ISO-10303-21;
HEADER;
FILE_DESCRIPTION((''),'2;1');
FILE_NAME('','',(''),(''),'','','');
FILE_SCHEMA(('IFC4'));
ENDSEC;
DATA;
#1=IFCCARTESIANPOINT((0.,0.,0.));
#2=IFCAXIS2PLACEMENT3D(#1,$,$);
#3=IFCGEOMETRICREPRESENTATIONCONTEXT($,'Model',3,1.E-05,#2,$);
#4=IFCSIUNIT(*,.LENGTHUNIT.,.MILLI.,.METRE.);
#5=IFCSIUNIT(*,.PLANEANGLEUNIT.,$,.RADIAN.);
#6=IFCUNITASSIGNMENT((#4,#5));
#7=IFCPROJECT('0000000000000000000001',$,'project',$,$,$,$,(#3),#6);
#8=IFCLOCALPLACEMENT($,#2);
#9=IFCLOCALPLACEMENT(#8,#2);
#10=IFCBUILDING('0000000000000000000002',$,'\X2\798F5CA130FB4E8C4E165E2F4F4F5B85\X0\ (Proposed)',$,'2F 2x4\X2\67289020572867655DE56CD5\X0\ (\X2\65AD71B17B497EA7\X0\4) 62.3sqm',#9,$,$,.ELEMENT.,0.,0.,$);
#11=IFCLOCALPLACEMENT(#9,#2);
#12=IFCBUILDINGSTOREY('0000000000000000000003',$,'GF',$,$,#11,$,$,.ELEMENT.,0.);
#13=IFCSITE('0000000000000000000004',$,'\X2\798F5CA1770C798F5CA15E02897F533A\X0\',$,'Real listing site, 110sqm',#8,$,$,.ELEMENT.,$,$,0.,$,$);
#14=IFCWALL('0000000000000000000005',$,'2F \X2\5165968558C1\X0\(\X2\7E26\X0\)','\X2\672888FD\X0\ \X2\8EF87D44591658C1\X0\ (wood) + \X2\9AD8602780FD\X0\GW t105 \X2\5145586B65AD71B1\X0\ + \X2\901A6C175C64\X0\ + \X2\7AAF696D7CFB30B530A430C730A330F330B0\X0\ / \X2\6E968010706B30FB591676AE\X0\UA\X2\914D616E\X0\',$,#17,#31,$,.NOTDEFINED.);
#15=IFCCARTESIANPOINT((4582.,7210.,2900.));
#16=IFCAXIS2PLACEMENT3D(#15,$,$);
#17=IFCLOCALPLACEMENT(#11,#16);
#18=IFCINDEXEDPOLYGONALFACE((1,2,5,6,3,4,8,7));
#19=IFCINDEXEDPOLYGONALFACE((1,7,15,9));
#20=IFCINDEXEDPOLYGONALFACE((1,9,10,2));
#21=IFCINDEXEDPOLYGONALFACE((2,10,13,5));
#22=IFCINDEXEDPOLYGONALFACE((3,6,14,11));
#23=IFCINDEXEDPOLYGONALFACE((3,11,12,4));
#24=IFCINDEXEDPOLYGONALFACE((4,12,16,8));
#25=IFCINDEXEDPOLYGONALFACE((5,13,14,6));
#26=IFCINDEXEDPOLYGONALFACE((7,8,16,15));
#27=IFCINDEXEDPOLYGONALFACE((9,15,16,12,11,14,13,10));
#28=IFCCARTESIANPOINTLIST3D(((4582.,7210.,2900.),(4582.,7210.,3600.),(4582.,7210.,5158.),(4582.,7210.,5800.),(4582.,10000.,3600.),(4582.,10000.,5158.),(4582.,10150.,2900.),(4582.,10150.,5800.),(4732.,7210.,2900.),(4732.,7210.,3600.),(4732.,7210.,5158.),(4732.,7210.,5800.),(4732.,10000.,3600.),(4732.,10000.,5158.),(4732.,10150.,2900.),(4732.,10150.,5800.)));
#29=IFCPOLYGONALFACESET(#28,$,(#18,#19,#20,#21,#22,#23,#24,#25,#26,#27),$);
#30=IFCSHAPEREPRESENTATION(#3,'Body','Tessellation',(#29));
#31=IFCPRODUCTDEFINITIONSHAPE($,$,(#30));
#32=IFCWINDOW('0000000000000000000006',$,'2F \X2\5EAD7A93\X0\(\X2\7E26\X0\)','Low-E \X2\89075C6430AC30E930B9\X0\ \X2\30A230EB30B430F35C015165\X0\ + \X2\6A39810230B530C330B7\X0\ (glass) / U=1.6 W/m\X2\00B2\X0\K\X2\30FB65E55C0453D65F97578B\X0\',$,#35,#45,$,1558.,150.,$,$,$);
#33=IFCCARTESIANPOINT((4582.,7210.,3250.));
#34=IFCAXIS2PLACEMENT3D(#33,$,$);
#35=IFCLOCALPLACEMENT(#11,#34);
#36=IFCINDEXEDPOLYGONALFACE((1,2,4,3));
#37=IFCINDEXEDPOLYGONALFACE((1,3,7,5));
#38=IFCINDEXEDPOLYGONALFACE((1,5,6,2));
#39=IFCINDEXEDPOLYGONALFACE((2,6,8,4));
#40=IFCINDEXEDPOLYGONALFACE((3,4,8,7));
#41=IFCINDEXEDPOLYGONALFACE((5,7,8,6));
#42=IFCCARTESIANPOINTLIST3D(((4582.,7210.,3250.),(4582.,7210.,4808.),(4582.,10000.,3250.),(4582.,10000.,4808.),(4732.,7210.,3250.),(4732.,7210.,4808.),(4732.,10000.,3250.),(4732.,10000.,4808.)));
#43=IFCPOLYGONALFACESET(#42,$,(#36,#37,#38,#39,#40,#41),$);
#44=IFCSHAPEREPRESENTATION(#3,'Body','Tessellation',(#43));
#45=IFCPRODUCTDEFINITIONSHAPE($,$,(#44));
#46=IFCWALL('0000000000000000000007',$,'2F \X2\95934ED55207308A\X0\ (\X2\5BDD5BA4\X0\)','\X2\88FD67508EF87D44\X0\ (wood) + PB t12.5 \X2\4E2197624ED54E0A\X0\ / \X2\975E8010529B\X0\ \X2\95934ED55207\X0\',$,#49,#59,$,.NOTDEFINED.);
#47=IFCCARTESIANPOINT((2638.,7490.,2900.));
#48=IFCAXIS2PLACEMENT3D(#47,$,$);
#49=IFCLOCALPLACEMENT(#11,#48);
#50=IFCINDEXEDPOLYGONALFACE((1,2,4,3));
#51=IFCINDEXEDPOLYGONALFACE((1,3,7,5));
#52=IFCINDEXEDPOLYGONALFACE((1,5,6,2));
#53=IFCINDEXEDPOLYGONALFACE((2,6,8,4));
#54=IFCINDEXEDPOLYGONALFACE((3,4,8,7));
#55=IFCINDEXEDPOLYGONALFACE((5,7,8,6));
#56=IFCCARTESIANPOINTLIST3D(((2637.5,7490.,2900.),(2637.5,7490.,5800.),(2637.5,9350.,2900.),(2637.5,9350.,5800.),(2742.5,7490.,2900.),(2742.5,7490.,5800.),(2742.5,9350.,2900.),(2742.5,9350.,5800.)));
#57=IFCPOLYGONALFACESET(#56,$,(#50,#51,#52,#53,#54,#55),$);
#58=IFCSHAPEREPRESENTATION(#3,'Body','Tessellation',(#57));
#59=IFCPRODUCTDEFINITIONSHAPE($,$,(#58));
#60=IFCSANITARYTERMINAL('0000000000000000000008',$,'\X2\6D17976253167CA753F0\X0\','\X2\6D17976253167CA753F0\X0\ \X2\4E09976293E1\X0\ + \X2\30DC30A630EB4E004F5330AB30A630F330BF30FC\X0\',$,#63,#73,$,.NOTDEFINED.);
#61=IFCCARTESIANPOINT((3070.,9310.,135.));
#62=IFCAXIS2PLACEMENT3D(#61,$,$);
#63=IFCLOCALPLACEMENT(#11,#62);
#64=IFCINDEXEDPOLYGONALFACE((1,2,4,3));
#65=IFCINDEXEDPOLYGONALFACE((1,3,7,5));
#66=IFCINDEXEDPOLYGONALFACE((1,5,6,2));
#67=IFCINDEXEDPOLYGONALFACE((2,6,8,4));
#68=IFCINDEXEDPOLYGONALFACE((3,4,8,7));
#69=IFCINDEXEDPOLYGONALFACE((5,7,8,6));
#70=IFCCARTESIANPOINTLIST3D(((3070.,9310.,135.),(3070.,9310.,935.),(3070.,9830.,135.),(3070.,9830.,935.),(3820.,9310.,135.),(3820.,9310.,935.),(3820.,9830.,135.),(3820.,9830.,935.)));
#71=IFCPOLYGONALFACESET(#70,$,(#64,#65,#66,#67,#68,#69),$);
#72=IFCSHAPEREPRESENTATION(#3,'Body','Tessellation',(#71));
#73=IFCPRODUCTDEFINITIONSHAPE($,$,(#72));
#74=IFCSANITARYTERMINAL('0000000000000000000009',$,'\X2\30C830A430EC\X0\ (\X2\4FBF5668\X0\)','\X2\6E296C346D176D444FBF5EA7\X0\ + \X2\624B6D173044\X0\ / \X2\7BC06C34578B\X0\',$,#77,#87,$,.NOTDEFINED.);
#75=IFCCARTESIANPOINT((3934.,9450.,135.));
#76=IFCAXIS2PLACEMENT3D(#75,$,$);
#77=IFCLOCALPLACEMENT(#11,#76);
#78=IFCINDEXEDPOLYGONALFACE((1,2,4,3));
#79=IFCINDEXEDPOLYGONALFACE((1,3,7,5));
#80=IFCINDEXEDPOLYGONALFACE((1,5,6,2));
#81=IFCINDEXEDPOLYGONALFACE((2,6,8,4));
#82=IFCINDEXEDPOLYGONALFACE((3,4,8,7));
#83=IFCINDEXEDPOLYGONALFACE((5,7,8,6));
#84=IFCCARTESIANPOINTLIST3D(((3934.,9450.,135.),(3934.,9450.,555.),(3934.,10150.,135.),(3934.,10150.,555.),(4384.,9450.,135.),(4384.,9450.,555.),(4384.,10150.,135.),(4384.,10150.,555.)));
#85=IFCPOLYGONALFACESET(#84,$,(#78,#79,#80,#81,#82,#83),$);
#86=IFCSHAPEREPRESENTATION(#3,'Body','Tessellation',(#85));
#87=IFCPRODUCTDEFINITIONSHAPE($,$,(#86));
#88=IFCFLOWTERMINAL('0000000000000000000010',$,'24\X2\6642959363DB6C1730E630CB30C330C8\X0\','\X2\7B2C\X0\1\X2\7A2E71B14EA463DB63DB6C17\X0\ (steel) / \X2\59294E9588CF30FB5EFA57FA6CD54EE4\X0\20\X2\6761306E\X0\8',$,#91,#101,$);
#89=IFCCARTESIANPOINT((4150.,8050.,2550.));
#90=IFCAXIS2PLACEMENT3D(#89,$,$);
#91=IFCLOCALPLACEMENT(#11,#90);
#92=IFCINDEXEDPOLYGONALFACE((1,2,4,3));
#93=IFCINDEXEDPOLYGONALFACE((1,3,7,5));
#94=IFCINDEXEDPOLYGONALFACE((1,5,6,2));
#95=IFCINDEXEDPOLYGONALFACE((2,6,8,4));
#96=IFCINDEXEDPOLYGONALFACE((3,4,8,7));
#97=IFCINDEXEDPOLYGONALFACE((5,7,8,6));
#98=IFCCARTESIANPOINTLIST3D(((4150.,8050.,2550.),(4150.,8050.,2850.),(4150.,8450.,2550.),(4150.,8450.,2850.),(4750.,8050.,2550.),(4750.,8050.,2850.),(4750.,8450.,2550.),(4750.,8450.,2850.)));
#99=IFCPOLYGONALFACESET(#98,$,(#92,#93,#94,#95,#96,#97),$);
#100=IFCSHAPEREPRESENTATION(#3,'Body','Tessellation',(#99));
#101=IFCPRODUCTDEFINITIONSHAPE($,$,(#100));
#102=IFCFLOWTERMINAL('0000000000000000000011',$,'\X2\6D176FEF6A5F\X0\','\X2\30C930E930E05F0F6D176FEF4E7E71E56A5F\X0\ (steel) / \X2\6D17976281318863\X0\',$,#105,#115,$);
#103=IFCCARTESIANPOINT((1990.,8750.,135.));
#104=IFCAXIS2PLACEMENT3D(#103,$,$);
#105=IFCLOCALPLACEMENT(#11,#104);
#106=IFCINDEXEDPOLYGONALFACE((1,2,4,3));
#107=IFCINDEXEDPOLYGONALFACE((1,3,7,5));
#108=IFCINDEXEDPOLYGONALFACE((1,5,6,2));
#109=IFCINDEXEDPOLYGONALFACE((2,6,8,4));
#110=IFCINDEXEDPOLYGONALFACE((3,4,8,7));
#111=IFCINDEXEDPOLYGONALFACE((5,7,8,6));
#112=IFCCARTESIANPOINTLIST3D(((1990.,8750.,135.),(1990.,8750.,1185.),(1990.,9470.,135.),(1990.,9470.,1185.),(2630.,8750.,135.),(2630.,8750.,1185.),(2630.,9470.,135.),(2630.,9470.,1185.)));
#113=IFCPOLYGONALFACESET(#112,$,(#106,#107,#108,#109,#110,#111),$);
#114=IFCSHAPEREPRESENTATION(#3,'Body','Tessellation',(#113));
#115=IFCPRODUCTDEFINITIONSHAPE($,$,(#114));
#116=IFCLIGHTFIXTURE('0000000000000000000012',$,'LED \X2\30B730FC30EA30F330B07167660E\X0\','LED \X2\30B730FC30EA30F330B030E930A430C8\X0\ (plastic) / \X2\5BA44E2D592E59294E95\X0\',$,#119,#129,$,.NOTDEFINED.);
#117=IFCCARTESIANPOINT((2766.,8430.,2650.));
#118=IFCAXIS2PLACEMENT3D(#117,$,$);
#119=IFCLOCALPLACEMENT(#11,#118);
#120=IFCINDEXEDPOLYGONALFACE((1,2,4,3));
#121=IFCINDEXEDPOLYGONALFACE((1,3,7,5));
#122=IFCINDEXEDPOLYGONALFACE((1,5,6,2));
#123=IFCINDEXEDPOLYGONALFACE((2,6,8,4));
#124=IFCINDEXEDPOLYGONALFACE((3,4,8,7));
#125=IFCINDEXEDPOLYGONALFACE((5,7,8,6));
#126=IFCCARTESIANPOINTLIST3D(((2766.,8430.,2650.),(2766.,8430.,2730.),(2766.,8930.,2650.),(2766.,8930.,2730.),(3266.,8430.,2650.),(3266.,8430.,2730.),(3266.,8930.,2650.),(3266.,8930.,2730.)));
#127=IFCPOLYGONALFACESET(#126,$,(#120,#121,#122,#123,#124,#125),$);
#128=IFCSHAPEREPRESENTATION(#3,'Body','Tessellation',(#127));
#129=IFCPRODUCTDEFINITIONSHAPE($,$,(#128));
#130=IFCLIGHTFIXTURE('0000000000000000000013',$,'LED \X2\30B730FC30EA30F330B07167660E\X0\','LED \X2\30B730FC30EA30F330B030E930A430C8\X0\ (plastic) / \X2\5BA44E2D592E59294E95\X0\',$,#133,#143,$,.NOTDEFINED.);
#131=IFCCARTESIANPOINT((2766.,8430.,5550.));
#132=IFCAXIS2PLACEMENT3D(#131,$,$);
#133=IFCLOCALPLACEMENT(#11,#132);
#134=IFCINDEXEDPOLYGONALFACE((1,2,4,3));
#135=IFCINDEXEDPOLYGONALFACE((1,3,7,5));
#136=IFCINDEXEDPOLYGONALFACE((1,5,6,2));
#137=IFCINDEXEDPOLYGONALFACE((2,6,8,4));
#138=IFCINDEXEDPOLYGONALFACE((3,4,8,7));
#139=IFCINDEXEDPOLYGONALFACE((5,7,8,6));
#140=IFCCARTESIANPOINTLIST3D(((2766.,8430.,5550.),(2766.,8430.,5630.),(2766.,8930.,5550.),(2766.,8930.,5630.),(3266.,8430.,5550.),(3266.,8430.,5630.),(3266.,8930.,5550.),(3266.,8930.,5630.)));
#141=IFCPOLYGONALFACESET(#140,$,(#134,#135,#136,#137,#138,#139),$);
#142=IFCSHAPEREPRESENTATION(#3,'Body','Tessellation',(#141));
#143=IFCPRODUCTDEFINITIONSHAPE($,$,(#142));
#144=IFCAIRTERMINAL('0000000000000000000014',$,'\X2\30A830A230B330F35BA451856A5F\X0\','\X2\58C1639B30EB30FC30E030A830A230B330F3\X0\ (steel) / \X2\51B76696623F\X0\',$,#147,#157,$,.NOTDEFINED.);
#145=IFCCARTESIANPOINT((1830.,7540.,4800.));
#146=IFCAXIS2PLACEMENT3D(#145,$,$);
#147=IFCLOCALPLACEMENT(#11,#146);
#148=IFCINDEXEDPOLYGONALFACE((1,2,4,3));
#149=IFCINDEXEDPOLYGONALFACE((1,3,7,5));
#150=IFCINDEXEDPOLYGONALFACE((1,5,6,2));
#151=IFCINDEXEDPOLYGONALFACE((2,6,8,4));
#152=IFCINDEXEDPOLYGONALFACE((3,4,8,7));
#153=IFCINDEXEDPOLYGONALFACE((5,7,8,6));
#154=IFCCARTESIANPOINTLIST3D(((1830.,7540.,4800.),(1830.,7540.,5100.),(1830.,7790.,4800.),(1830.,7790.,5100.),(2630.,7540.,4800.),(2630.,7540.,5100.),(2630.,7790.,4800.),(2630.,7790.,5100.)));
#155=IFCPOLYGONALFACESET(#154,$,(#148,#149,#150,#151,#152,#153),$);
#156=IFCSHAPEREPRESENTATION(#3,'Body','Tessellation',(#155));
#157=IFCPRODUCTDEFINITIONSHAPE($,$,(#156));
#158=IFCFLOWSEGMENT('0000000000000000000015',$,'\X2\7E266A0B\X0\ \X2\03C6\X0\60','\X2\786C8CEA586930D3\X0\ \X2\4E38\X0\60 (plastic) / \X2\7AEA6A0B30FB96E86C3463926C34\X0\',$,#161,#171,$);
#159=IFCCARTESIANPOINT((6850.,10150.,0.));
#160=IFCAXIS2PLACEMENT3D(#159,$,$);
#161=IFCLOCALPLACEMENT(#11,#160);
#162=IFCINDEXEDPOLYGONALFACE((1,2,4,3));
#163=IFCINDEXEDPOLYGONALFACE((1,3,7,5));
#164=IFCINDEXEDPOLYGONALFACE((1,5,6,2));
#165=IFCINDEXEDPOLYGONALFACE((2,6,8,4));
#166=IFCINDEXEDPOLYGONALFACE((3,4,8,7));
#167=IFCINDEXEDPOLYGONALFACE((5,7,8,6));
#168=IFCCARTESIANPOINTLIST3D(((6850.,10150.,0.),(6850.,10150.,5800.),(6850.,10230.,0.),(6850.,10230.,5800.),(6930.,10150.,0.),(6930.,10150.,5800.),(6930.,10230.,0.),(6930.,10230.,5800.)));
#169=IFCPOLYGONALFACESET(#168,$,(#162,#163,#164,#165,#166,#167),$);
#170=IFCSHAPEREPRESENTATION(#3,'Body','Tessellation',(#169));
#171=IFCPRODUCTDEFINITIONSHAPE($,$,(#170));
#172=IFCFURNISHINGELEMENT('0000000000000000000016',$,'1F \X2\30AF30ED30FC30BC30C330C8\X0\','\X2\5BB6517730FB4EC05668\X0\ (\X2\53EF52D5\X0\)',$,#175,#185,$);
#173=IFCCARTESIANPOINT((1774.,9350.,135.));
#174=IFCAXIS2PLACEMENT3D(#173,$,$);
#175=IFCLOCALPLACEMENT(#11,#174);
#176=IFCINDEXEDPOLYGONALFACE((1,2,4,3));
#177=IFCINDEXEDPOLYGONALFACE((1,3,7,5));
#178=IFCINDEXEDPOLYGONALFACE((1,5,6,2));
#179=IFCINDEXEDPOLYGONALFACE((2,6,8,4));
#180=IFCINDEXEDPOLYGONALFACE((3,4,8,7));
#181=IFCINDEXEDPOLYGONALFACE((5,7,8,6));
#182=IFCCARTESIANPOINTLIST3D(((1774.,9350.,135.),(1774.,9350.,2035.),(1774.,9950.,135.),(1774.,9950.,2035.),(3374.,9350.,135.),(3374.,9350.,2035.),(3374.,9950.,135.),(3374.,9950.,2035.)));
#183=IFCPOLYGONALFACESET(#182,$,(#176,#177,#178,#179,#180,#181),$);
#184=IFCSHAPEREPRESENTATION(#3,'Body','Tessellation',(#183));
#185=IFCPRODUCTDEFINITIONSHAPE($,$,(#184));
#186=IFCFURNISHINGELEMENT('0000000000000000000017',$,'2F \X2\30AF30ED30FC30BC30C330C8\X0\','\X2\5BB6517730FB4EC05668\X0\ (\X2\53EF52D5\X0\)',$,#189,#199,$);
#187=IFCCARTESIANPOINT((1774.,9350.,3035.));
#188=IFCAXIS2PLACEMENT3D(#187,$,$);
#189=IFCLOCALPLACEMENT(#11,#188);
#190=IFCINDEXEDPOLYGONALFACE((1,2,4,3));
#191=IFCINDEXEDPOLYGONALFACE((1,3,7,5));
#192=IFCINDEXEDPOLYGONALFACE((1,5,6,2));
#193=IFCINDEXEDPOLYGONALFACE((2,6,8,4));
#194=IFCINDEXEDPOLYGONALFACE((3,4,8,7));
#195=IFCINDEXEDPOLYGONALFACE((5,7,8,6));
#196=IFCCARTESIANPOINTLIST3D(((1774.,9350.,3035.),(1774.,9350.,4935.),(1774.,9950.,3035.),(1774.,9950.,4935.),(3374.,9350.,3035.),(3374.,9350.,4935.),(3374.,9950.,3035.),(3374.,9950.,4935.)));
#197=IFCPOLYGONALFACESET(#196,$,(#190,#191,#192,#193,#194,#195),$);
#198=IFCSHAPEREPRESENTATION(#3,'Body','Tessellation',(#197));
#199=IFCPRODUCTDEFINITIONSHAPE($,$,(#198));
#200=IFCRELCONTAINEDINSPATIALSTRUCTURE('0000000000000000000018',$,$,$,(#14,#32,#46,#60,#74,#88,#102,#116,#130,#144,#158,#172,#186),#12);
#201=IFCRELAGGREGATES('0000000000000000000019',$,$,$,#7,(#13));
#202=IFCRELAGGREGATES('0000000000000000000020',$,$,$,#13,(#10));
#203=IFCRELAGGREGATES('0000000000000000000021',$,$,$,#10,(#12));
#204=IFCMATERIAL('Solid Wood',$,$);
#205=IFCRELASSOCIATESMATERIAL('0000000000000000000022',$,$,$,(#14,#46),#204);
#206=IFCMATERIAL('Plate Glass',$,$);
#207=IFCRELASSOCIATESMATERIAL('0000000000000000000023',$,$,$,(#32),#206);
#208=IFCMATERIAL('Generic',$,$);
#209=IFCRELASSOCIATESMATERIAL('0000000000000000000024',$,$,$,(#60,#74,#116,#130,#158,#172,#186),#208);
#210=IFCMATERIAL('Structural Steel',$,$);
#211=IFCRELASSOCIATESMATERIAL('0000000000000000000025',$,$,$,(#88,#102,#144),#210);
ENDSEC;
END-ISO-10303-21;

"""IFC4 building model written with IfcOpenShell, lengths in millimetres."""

from ifc_helpers import new_model, si_unit, frame, frame_2d, origin, place, context, project, spatial, rectangle, extrude, material, element, fill, save


model = new_model("IFC4")

# Units and contexts
model_context = context("Model", 3, precision=1e-05, world=origin())
ifc_project = project(units=[si_unit("LENGTHUNIT", "METRE", prefix="MILLI"), si_unit("PLANEANGLEUNIT", "RADIAN")], contexts=[model_context])

# Site, building, storey
site_placement = place(None, origin())
site = spatial("IfcSite", under=ifc_project, at=site_placement, Name="福岡県福岡市西区", ObjectType="Real listing site, 110sqm", CompositionType="ELEMENT", RefElevation=0.0)
building_placement = place(site_placement, origin())
building = spatial("IfcBuilding", under=site, at=building_placement, Name="福岡・二世帯住宅 (Proposed)", ObjectType="2F 2x4木造在来工法 (断熱等级4) 62.3sqm", CompositionType="ELEMENT", ElevationOfRefHeight=0.0, ElevationOfTerrain=0.0)
storey_placement = place(building_placement, origin())
storey = spatial("IfcBuildingStorey", under=building, at=storey_placement, Name="GF", CompositionType="ELEMENT", Elevation=0.0)

# Shared definitions
ifc_material_1 = material(Name="Solid Wood")

# Shared definitions
ifc_material_2 = material(Name="Plate Glass")

# Wall, opening, window
wall_1_placement = place(storey_placement, frame((4582.0, 7210.0, 2900.0)))
wall_1 = element("IfcWall", 1, at=wall_1_placement, inside=storey, material=ifc_material_1, Name="2F 入隅壁(縦)", Description="木製 軸組外壁 (wood) + 高性能GW t105 充填断熱 + 通気層 + 窯業系サイディング / 準耐火・外皮UA配慮", PredefinedType="NOTDEFINED", context=model_context, shape_type="SweptSolid", body=[
    extrude(rectangle(XDim=150.0, YDim=2940.0, at=frame_2d((75.0, 1470.0))), frame((4582.0, 7210.0, 2900.0)), (0.0, 0.0, 1.0), 2900.0),
])
opening_1_placement = place(storey_placement, frame((4582.0, 7210.0, 3250.0)))
opening_1 = element("IfcOpeningElement", 2, at=opening_1_placement, cuts=wall_1, PredefinedType="NOTDEFINED", context=model_context, shape_type="SweptSolid", body=[
    extrude(rectangle(XDim=150.0, YDim=2790.0, at=frame_2d((75.0, 1395.0))), frame((4582.0, 7210.0, 3250.0)), (0.0, 0.0, 1.0), 1558.0),
])
window_1_placement = place(storey_placement, frame((4582.0, 7210.0, 3250.0)))
window_1 = element("IfcWindow", 3, at=window_1_placement, inside=storey, material=ifc_material_2, Name="2F 庭窓(縦)", Description="Low-E 複層ガラス アルゴン封入 + 樹脂サッシ (glass) / U=1.6 W/m²K・日射取得型", OverallHeight=1558.0, OverallWidth=150.0, context=model_context, shape_type="SweptSolid", body=[
    extrude(rectangle(XDim=150.0, YDim=2790.0, at=frame_2d((75.0, 1395.0))), frame((4582.0, 7210.0, 3250.0)), (0.0, 0.0, 1.0), 1558.0),
])
fill(opening_1, window_1)

# Wall
wall_2_placement = place(storey_placement, frame((2638.0, 7490.0, 2900.0)))
element("IfcWall", 4, at=wall_2_placement, inside=storey, material=ifc_material_1, Name="2F 間仕切り (寝室)", Description="製材軸組 (wood) + PB t12.5 両面仕上 / 非耐力 間仕切", PredefinedType="NOTDEFINED", context=model_context, shape_type="SweptSolid", body=[
    extrude(rectangle(XDim=105.0, YDim=1860.0, at=frame_2d((52.0, 930.0))), frame((2638.0, 7490.0, 2900.0)), (0.0, 0.0, 1.0), 2900.0),
])

# Sanitary terminals
ifc_material_3 = material(Name="Generic")
sanitary_terminal_1_placement = place(storey_placement, frame((3070.0, 9310.0, 135.0)))
element("IfcSanitaryTerminal", 5, at=sanitary_terminal_1_placement, inside=storey, material=ifc_material_3, Name="洗面化粧台", Description="洗面化粧台 三面鏡 + ボウル一体カウンター", PredefinedType="NOTDEFINED", context=model_context, shape_type="SweptSolid", body=[
    extrude(rectangle(XDim=750.0, YDim=520.0, at=frame_2d((375.0, 260.0))), frame((3070.0, 9310.0, 135.0)), (0.0, 0.0, 1.0), 800.0),
])
sanitary_terminal_2_placement = place(storey_placement, frame((3934.0, 9450.0, 135.0)))
element("IfcSanitaryTerminal", 6, at=sanitary_terminal_2_placement, inside=storey, material=ifc_material_3, Name="トイレ (便器)", Description="温水洗浄便座 + 手洗い / 節水型", PredefinedType="NOTDEFINED", context=model_context, shape_type="SweptSolid", body=[
    extrude(rectangle(XDim=450.0, YDim=700.0, at=frame_2d((225.0, 350.0))), frame((3934.0, 9450.0, 135.0)), (0.0, 0.0, 1.0), 420.0),
])

# Flow terminals
ifc_material_4 = material(Name="Structural Steel")
flow_terminal_1_placement = place(storey_placement, frame((4150.0, 8050.0, 2550.0)))
element("IfcFlowTerminal", 7, at=flow_terminal_1_placement, inside=storey, material=ifc_material_4, Name="24時間換気ユニット", Description="第1種熱交換換気 (steel) / 天井裏・建基法令20条の8", context=model_context, shape_type="SweptSolid", body=[
    extrude(rectangle(XDim=600.0, YDim=400.0, at=frame_2d((300.0, 200.0))), frame((4150.0, 8050.0, 2550.0)), (0.0, 0.0, 1.0), 300.0),
])
flow_terminal_2_placement = place(storey_placement, frame((1990.0, 8750.0, 135.0)))
element("IfcFlowTerminal", 8, at=flow_terminal_2_placement, inside=storey, material=ifc_material_4, Name="洗濯機", Description="ドラム式洗濯乾燥機 (steel) / 洗面脱衣", context=model_context, shape_type="SweptSolid", body=[
    extrude(rectangle(XDim=640.0, YDim=720.0, at=frame_2d((320.0, 360.0))), frame((1990.0, 8750.0, 135.0)), (0.0, 0.0, 1.0), 1050.0),
])

# Light fixtures
light_fixture_1_placement = place(storey_placement, frame((2766.0, 8430.0, 2650.0)))
element("IfcLightFixture", 9, at=light_fixture_1_placement, inside=storey, material=ifc_material_3, Name="LED シーリング照明", Description="LED シーリングライト (plastic) / 室中央天井", PredefinedType="NOTDEFINED", context=model_context, shape_type="SweptSolid", body=[
    extrude(rectangle(XDim=500.0, YDim=500.0, at=frame_2d((250.0, 250.0))), frame((2766.0, 8430.0, 2650.0)), (0.0, 0.0, 1.0), 80.0),
])
light_fixture_2_placement = place(storey_placement, frame((2766.0, 8430.0, 5550.0)))
element("IfcLightFixture", 10, at=light_fixture_2_placement, inside=storey, material=ifc_material_3, Name="LED シーリング照明", Description="LED シーリングライト (plastic) / 室中央天井", PredefinedType="NOTDEFINED", context=model_context, shape_type="SweptSolid", body=[
    extrude(rectangle(XDim=500.0, YDim=500.0, at=frame_2d((250.0, 250.0))), frame((2766.0, 8430.0, 5550.0)), (0.0, 0.0, 1.0), 80.0),
])

# Air terminal
air_terminal_placement = place(storey_placement, frame((1830.0, 7540.0, 4800.0)))
element("IfcAirTerminal", 11, at=air_terminal_placement, inside=storey, material=ifc_material_4, Name="エアコン室内機", Description="壁掛ルームエアコン (steel) / 冷暖房", PredefinedType="NOTDEFINED", context=model_context, shape_type="SweptSolid", body=[
    extrude(rectangle(XDim=800.0, YDim=250.0, at=frame_2d((400.0, 125.0))), frame((1830.0, 7540.0, 4800.0)), (0.0, 0.0, 1.0), 300.0),
])

# Flow segment
flow_segment_placement = place(storey_placement, frame((6850.0, 10150.0, 0.0)))
element("IfcFlowSegment", 12, at=flow_segment_placement, inside=storey, material=ifc_material_3, Name="縦樋 φ60", Description="硬質塩ビ 丸60 (plastic) / 竪樋・雨水排水", context=model_context, shape_type="SweptSolid", body=[
    extrude(rectangle(XDim=80.0, YDim=80.0, at=frame_2d((40.0, 40.0))), frame((6850.0, 10150.0, 0.0)), (0.0, 0.0, 1.0), 5800.0),
])

# Furnishing elements
furnishing_1_placement = place(storey_placement, frame((1774.0, 9350.0, 135.0)))
element("IfcFurnishingElement", 13, at=furnishing_1_placement, inside=storey, material=ifc_material_3, Name="1F クローゼット", Description="家具・什器 (可動)", context=model_context, shape_type="SweptSolid", body=[
    extrude(rectangle(XDim=1600.0, YDim=600.0, at=frame_2d((800.0, 300.0))), frame((1774.0, 9350.0, 135.0)), (0.0, 0.0, 1.0), 1900.0),
])
furnishing_2_placement = place(storey_placement, frame((1774.0, 9350.0, 3035.0)))
element("IfcFurnishingElement", 14, at=furnishing_2_placement, inside=storey, material=ifc_material_3, Name="2F クローゼット", Description="家具・什器 (可動)", context=model_context, shape_type="SweptSolid", body=[
    extrude(rectangle(XDim=1600.0, YDim=600.0, at=frame_2d((800.0, 300.0))), frame((1774.0, 9350.0, 3035.0)), (0.0, 0.0, 1.0), 1900.0),
])

save(model, "model.ifc")
